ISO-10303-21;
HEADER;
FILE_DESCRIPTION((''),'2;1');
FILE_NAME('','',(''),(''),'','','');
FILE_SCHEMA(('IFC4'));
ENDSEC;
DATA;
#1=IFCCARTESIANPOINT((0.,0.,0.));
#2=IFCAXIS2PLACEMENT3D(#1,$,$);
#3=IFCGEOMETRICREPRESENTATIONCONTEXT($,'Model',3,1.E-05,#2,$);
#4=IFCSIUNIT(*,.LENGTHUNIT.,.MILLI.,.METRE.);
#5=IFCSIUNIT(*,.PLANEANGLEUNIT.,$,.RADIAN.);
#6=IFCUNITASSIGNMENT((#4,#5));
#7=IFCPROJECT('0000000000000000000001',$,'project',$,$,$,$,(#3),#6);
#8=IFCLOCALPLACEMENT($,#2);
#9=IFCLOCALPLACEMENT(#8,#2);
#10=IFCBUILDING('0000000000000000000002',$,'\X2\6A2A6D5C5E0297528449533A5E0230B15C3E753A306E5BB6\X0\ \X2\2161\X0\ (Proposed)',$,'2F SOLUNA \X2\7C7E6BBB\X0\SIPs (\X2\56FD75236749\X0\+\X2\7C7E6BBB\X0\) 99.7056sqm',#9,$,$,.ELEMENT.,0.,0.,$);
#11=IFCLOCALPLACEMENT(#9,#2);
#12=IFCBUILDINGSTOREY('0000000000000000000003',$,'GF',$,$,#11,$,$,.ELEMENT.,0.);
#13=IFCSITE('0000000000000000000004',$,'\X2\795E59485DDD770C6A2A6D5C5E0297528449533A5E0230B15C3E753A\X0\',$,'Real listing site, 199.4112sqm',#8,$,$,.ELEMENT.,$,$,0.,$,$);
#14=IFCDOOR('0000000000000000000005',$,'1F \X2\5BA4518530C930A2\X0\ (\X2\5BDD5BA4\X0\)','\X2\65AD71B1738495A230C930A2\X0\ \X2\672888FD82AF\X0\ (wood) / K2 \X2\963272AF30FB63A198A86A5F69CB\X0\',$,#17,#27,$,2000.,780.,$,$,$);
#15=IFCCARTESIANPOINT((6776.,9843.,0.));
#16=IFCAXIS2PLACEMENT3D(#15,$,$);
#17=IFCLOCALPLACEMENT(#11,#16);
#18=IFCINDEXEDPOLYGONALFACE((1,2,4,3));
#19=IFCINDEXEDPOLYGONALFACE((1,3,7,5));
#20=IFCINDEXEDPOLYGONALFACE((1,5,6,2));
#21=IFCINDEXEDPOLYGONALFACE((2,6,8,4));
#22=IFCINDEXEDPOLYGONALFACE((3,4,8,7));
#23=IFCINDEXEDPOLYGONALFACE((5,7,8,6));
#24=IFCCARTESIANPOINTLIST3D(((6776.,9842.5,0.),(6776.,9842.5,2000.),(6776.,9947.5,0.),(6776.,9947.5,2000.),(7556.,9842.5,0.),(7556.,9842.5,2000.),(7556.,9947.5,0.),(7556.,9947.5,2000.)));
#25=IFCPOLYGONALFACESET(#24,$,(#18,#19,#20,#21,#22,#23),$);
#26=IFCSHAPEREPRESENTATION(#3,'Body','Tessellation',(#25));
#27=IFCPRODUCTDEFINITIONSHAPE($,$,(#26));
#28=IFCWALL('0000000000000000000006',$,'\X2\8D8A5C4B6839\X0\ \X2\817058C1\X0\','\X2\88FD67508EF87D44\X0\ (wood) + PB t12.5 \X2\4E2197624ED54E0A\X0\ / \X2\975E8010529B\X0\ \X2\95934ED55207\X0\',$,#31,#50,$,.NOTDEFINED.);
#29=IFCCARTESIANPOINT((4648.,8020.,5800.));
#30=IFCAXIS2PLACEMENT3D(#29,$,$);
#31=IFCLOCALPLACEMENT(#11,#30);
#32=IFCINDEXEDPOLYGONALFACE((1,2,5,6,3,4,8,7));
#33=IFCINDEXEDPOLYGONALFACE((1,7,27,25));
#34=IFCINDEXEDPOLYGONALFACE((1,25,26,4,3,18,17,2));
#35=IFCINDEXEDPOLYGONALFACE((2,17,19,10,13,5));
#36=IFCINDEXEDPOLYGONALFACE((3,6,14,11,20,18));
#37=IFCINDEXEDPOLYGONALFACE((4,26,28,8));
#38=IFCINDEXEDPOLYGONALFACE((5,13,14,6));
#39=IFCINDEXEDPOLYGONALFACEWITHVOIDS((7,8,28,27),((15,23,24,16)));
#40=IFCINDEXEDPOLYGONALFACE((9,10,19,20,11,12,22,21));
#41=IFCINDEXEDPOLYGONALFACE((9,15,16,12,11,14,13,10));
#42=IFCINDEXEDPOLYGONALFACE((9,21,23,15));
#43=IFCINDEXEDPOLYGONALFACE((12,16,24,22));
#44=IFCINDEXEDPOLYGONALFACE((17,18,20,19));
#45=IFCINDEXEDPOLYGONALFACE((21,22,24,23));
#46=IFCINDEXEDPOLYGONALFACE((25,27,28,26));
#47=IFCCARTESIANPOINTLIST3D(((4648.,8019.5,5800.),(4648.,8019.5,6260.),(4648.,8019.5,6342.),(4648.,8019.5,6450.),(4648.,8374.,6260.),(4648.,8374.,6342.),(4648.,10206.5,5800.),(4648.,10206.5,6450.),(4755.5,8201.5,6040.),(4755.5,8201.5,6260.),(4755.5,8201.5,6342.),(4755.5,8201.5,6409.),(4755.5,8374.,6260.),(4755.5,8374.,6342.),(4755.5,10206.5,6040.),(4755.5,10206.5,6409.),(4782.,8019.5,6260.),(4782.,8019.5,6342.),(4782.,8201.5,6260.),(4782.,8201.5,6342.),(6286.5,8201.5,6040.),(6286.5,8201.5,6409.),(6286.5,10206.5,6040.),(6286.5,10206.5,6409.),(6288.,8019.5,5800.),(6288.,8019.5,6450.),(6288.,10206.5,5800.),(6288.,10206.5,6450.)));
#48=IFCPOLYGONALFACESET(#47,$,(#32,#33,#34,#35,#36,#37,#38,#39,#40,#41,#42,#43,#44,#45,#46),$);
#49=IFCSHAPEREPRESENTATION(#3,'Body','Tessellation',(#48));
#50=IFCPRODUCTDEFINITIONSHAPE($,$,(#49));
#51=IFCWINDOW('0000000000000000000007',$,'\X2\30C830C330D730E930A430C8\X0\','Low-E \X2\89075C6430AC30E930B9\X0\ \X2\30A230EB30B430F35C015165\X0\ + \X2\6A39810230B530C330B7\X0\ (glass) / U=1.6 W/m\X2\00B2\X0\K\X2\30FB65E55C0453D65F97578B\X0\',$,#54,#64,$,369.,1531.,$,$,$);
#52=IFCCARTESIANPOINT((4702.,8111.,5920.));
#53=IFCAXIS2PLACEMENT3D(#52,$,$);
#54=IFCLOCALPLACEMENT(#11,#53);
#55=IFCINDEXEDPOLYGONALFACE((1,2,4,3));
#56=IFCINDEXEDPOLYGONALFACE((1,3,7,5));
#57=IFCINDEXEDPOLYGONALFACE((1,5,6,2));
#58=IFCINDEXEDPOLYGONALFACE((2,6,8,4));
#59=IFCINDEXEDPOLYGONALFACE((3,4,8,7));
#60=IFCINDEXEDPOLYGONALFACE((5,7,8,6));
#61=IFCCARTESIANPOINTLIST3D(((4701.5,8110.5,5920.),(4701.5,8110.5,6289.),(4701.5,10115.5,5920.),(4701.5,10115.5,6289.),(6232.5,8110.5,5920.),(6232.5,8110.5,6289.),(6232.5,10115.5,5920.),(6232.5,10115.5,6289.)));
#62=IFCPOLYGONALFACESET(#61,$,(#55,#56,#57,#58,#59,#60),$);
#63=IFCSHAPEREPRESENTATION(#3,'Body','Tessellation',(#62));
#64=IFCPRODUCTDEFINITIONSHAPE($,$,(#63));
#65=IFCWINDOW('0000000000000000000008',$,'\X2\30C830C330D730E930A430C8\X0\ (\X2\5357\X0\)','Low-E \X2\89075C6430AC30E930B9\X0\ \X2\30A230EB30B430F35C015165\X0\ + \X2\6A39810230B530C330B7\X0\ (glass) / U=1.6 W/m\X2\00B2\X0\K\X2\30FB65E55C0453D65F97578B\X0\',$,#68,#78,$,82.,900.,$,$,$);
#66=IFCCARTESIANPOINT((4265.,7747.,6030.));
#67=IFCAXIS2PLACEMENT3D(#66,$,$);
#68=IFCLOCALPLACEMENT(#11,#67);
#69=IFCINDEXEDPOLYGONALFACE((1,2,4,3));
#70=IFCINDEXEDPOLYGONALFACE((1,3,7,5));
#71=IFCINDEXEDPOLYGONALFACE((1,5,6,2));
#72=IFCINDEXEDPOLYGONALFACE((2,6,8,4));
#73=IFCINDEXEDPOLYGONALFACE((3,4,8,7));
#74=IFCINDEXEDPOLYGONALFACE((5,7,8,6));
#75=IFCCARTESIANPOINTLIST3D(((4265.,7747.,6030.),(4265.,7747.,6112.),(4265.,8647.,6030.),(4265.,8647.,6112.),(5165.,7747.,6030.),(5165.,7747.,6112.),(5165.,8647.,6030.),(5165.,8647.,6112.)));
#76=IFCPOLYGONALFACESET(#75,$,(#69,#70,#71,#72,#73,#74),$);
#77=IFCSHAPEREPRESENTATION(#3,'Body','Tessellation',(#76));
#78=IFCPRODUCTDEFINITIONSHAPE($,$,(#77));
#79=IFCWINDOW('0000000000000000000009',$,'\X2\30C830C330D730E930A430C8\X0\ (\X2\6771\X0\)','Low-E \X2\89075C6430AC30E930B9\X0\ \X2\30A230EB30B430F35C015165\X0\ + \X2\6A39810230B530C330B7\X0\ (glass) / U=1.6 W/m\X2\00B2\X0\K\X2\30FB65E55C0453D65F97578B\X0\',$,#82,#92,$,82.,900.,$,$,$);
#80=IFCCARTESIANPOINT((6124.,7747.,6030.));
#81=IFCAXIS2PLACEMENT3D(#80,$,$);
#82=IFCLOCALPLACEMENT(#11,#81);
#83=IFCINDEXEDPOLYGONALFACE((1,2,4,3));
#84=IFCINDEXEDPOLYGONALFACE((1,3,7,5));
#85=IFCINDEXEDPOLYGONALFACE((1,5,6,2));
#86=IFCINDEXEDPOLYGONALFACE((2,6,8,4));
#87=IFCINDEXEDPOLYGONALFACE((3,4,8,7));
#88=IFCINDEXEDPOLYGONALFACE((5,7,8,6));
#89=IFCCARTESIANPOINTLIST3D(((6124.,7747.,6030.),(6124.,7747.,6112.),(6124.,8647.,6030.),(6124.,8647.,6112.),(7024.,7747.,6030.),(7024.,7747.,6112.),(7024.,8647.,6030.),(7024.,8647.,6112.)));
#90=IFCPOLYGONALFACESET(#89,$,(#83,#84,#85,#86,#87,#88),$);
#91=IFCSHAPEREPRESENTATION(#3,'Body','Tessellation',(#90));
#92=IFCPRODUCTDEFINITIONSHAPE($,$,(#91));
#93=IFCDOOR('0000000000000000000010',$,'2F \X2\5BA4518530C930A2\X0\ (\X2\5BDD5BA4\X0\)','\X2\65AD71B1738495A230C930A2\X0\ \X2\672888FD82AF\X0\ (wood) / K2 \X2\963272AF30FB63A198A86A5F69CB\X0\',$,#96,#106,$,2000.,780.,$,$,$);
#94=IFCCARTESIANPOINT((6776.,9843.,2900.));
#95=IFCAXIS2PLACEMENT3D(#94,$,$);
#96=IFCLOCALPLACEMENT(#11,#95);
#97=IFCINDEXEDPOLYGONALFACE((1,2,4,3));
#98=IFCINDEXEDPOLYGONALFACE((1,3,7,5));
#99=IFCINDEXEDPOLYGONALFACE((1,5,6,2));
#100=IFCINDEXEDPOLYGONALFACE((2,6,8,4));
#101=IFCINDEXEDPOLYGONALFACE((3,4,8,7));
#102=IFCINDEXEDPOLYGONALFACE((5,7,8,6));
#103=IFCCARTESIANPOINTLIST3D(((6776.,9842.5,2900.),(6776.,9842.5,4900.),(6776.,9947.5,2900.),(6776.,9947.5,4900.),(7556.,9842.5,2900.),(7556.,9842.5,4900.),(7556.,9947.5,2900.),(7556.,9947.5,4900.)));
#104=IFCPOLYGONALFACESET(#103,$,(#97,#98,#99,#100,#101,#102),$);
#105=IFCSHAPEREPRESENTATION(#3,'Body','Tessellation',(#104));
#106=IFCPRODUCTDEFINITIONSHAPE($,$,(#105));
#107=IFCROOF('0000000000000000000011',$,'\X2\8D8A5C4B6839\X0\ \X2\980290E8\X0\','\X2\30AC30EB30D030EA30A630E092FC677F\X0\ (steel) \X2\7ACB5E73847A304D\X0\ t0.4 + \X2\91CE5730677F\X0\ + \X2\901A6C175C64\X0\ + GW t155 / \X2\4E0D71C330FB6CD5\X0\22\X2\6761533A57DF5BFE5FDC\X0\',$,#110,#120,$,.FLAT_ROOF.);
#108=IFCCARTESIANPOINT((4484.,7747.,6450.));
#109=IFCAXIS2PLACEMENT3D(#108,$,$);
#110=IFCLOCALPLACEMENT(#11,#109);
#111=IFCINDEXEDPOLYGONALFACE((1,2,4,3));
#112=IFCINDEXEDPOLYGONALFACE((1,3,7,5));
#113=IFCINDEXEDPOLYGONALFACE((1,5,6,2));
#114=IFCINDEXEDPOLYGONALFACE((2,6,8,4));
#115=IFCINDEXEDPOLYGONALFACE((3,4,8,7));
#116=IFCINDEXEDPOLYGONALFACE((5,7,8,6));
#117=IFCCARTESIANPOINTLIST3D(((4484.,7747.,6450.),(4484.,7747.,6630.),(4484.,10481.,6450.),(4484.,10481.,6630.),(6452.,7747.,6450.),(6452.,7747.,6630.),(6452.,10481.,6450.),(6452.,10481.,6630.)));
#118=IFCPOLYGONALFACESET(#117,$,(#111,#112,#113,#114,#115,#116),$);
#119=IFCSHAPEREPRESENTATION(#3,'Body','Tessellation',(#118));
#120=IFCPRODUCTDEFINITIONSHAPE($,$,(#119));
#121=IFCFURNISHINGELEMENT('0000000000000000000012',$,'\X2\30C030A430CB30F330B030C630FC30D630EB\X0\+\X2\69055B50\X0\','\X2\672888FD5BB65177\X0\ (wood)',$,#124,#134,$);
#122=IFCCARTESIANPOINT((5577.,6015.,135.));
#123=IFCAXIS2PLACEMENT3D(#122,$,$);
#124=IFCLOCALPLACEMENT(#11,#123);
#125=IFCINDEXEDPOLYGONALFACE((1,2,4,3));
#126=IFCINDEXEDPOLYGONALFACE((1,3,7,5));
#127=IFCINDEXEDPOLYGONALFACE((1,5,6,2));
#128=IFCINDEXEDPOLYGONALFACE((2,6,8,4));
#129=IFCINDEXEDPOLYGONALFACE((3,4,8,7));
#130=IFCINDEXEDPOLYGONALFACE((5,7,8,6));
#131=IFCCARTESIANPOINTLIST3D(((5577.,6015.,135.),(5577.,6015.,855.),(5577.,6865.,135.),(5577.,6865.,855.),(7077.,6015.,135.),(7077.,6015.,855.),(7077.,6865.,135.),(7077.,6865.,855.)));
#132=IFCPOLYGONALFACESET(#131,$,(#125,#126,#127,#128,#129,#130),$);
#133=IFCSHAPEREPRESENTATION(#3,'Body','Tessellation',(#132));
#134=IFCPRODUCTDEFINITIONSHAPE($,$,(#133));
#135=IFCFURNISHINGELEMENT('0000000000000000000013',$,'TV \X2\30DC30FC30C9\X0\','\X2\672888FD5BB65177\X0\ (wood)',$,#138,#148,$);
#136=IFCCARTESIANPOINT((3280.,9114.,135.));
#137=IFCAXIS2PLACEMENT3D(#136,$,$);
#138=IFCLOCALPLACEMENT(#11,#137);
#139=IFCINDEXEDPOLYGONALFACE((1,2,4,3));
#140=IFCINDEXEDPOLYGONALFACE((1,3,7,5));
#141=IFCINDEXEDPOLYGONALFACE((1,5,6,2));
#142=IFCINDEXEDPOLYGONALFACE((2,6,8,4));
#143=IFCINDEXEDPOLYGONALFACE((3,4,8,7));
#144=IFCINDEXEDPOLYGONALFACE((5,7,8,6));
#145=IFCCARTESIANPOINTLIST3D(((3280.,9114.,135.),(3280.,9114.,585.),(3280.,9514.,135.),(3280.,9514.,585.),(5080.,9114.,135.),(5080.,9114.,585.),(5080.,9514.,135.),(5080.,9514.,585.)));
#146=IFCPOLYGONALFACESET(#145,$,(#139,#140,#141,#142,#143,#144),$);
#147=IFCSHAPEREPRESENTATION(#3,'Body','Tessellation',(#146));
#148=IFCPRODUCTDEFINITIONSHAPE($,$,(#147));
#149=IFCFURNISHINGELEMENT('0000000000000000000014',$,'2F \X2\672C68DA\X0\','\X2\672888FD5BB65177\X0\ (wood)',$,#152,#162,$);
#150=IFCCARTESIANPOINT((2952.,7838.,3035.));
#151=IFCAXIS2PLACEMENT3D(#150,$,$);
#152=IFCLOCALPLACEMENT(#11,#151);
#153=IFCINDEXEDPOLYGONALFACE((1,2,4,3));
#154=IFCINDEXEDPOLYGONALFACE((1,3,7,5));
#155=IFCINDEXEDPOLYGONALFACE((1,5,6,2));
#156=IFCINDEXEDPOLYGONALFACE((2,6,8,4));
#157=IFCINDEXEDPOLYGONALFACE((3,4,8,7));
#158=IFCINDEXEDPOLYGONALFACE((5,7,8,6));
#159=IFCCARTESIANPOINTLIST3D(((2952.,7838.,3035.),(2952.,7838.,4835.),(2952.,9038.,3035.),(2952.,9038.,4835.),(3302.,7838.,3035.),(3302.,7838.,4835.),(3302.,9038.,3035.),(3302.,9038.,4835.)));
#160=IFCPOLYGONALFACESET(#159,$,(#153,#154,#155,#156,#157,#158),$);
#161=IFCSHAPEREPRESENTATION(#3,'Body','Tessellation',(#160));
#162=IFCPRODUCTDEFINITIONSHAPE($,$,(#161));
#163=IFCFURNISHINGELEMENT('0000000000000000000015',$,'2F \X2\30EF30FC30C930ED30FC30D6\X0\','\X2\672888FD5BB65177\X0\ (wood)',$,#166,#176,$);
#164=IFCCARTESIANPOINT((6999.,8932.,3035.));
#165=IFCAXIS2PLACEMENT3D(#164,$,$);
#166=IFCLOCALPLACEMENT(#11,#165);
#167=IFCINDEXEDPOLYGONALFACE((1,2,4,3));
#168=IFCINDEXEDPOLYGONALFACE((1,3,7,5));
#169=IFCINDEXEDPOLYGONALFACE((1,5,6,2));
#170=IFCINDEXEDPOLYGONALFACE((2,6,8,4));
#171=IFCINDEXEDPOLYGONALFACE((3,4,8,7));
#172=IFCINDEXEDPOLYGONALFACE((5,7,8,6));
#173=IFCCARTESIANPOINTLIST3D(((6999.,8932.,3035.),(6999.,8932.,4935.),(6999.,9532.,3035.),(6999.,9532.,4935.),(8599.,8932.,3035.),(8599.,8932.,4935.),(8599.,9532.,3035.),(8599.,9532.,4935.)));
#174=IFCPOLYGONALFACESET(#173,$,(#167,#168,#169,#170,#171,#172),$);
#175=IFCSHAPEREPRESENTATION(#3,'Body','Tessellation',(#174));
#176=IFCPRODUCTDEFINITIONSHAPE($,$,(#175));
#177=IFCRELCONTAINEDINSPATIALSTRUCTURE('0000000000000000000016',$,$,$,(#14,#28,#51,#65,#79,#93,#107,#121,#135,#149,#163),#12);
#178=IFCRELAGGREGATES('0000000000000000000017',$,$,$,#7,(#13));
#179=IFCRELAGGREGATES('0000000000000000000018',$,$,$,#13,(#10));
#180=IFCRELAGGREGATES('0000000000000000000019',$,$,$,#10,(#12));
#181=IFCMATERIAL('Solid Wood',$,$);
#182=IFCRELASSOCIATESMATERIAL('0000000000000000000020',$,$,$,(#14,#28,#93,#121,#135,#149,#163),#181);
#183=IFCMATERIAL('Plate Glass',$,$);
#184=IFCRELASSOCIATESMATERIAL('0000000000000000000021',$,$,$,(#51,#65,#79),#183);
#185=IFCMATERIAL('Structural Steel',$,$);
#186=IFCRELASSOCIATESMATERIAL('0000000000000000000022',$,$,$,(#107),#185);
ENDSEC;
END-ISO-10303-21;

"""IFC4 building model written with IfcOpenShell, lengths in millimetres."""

from ifc_helpers import new_model, si_unit, frame, frame_2d, origin, place, context, project, spatial, rectangle, extrude, material, element, fill, save


model = new_model("IFC4")

# Units and contexts
model_context = context("Model", 3, precision=1e-05, world=origin())
ifc_project = project(units=[si_unit("LENGTHUNIT", "METRE", prefix="MILLI"), si_unit("PLANEANGLEUNIT", "RADIAN")], contexts=[model_context])

# Site, building, storey
site_placement = place(None, origin())
site = spatial("IfcSite", under=ifc_project, at=site_placement, Name="神奈川県横浜市青葉区市ケ尾町", ObjectType="Real listing site, 199.4112sqm", CompositionType="ELEMENT", RefElevation=0.0)
building_placement = place(site_placement, origin())
building = spatial("IfcBuilding", under=site, at=building_placement, Name="横浜市青葉区市ケ尾町の家 Ⅱ (Proposed)", ObjectType="2F SOLUNA 籾殻SIPs (国産杉+籾殻) 99.7056sqm", CompositionType="ELEMENT", ElevationOfRefHeight=0.0, ElevationOfTerrain=0.0)
storey_placement = place(building_placement, origin())
storey = spatial("IfcBuildingStorey", under=building, at=storey_placement, Name="GF", CompositionType="ELEMENT", Elevation=0.0)

# Shared definitions
ifc_material_1 = material(Name="Solid Wood")

# Door
door_1_placement = place(storey_placement, frame((6776.0, 9843.0, 0.0)))
element("IfcDoor", 1, at=door_1_placement, inside=storey, material=ifc_material_1, Name="1F 室内ドア (寝室)", Description="断熱玄関ドア 木製芯 (wood) / K2 防犯・採風機構", OverallHeight=2000.0, OverallWidth=780.0, context=model_context, shape_type="SweptSolid", body=[
    extrude(rectangle(XDim=780.0, YDim=105.0, at=frame_2d((390.0, 52.0))), frame((6776.0, 9843.0, 0.0)), (0.0, 0.0, 1.0), 2000.0),
])

# Wall, openings, windows
wall_1_placement = place(storey_placement, frame((4648.0, 8020.0, 5800.0)))
wall_1 = element("IfcWall", 2, at=wall_1_placement, inside=storey, material=ifc_material_1, Name="越屋根 腰壁", Description="製材軸組 (wood) + PB t12.5 両面仕上 / 非耐力 間仕切", PredefinedType="NOTDEFINED", context=model_context, shape_type="SweptSolid", body=[
    extrude(rectangle(XDim=1640.0, YDim=2187.0, at=frame_2d((820.0, 1093.0))), frame((4648.0, 8020.0, 5800.0)), (0.0, 0.0, 1.0), 650.0),
])
opening_1_placement = place(storey_placement, frame((4702.0, 8111.0, 5920.0)))
opening_1 = element("IfcOpeningElement", 3, at=opening_1_placement, cuts=wall_1, PredefinedType="NOTDEFINED", context=model_context, shape_type="SweptSolid", body=[
    extrude(rectangle(XDim=1531.0, YDim=2005.0, at=frame_2d((765.0, 1002.0))), frame((4702.0, 8111.0, 5920.0)), (0.0, 0.0, 1.0), 369.0),
])
opening_2_placement = place(storey_placement, frame((4265.0, 7747.0, 6030.0)))
opening_2 = element("IfcOpeningElement", 4, at=opening_2_placement, cuts=wall_1, PredefinedType="NOTDEFINED", context=model_context, shape_type="SweptSolid", body=[
    extrude(rectangle(XDim=900.0, YDim=900.0, at=frame_2d((450.0, 450.0))), frame((4265.0, 7747.0, 6030.0)), (0.0, 0.0, 1.0), 82.0),
])
opening_3_placement = place(storey_placement, frame((6124.0, 7747.0, 6030.0)))
opening_3 = element("IfcOpeningElement", 5, at=opening_3_placement, cuts=wall_1, PredefinedType="NOTDEFINED", context=model_context, shape_type="SweptSolid", body=[
    extrude(rectangle(XDim=900.0, YDim=900.0, at=frame_2d((450.0, 450.0))), frame((6124.0, 7747.0, 6030.0)), (0.0, 0.0, 1.0), 82.0),
])
ifc_material_2 = material(Name="Plate Glass")
window_1_placement = place(storey_placement, frame((4702.0, 8111.0, 5920.0)))
window_1 = element("IfcWindow", 6, at=window_1_placement, inside=storey, material=ifc_material_2, Name="トップライト", Description="Low-E 複層ガラス アルゴン封入 + 樹脂サッシ (glass) / U=1.6 W/m²K・日射取得型", OverallHeight=369.0, OverallWidth=1531.0, context=model_context, shape_type="SweptSolid", body=[
    extrude(rectangle(XDim=1531.0, YDim=2005.0, at=frame_2d((765.0, 1002.0))), frame((4702.0, 8111.0, 5920.0)), (0.0, 0.0, 1.0), 369.0),
])
fill(opening_1, window_1)
window_2_placement = place(storey_placement, frame((4265.0, 7747.0, 6030.0)))
window_2 = element("IfcWindow", 7, at=window_2_placement, inside=storey, material=ifc_material_2, Name="トップライト (南)", Description="Low-E 複層ガラス アルゴン封入 + 樹脂サッシ (glass) / U=1.6 W/m²K・日射取得型", OverallHeight=82.0, OverallWidth=900.0, context=model_context, shape_type="SweptSolid", body=[
    extrude(rectangle(XDim=900.0, YDim=900.0, at=frame_2d((450.0, 450.0))), frame((4265.0, 7747.0, 6030.0)), (0.0, 0.0, 1.0), 82.0),
])
fill(opening_2, window_2)
window_3_placement = place(storey_placement, frame((6124.0, 7747.0, 6030.0)))
window_3 = element("IfcWindow", 8, at=window_3_placement, inside=storey, material=ifc_material_2, Name="トップライト (東)", Description="Low-E 複層ガラス アルゴン封入 + 樹脂サッシ (glass) / U=1.6 W/m²K・日射取得型", OverallHeight=82.0, OverallWidth=900.0, context=model_context, shape_type="SweptSolid", body=[
    extrude(rectangle(XDim=900.0, YDim=900.0, at=frame_2d((450.0, 450.0))), frame((6124.0, 7747.0, 6030.0)), (0.0, 0.0, 1.0), 82.0),
])
fill(opening_3, window_3)

# Door
door_2_placement = place(storey_placement, frame((6776.0, 9843.0, 2900.0)))
element("IfcDoor", 9, at=door_2_placement, inside=storey, material=ifc_material_1, Name="2F 室内ドア (寝室)", Description="断熱玄関ドア 木製芯 (wood) / K2 防犯・採風機構", OverallHeight=2000.0, OverallWidth=780.0, context=model_context, shape_type="SweptSolid", body=[
    extrude(rectangle(XDim=780.0, YDim=105.0, at=frame_2d((390.0, 52.0))), frame((6776.0, 9843.0, 2900.0)), (0.0, 0.0, 1.0), 2000.0),
])

# Roof
ifc_material_3 = material(Name="Structural Steel")
roof_placement = place(storey_placement, frame((4484.0, 7747.0, 6450.0)))
element("IfcRoof", 10, at=roof_placement, inside=storey, material=ifc_material_3, Name="越屋根 頂部", Description="ガルバリウム鋼板 (steel) 立平葺き t0.4 + 野地板 + 通気層 + GW t155 / 不燃・法22条区域対応", PredefinedType="FLAT_ROOF", context=model_context, shape_type="SweptSolid", body=[
    extrude(rectangle(XDim=1968.0, YDim=2734.0, at=frame_2d((984.0, 1367.0))), frame((4484.0, 7747.0, 6450.0)), (0.0, 0.0, 1.0), 180.0),
])

# Furnishing elements
furnishing_1_placement = place(storey_placement, frame((5577.0, 6015.0, 135.0)))
element("IfcFurnishingElement", 11, at=furnishing_1_placement, inside=storey, material=ifc_material_1, Name="ダイニングテーブル+椅子", Description="木製家具 (wood)", context=model_context, shape_type="SweptSolid", body=[
    extrude(rectangle(XDim=1500.0, YDim=850.0, at=frame_2d((750.0, 425.0))), frame((5577.0, 6015.0, 135.0)), (0.0, 0.0, 1.0), 720.0),
])
furnishing_2_placement = place(storey_placement, frame((3280.0, 9114.0, 135.0)))
element("IfcFurnishingElement", 12, at=furnishing_2_placement, inside=storey, material=ifc_material_1, Name="TV ボード", Description="木製家具 (wood)", context=model_context, shape_type="SweptSolid", body=[
    extrude(rectangle(XDim=1800.0, YDim=400.0, at=frame_2d((900.0, 200.0))), frame((3280.0, 9114.0, 135.0)), (0.0, 0.0, 1.0), 450.0),
])
furnishing_3_placement = place(storey_placement, frame((2952.0, 7838.0, 3035.0)))
element("IfcFurnishingElement", 13, at=furnishing_3_placement, inside=storey, material=ifc_material_1, Name="2F 本棚", Description="木製家具 (wood)", context=model_context, shape_type="SweptSolid", body=[
    extrude(rectangle(XDim=350.0, YDim=1200.0, at=frame_2d((175.0, 600.0))), frame((2952.0, 7838.0, 3035.0)), (0.0, 0.0, 1.0), 1800.0),
])
furnishing_4_placement = place(storey_placement, frame((6999.0, 8932.0, 3035.0)))
element("IfcFurnishingElement", 14, at=furnishing_4_placement, inside=storey, material=ifc_material_1, Name="2F ワードローブ", Description="木製家具 (wood)", context=model_context, shape_type="SweptSolid", body=[
    extrude(rectangle(XDim=1600.0, YDim=600.0, at=frame_2d((800.0, 300.0))), frame((6999.0, 8932.0, 3035.0)), (0.0, 0.0, 1.0), 1900.0),
])

save(model, "model.ifc")
